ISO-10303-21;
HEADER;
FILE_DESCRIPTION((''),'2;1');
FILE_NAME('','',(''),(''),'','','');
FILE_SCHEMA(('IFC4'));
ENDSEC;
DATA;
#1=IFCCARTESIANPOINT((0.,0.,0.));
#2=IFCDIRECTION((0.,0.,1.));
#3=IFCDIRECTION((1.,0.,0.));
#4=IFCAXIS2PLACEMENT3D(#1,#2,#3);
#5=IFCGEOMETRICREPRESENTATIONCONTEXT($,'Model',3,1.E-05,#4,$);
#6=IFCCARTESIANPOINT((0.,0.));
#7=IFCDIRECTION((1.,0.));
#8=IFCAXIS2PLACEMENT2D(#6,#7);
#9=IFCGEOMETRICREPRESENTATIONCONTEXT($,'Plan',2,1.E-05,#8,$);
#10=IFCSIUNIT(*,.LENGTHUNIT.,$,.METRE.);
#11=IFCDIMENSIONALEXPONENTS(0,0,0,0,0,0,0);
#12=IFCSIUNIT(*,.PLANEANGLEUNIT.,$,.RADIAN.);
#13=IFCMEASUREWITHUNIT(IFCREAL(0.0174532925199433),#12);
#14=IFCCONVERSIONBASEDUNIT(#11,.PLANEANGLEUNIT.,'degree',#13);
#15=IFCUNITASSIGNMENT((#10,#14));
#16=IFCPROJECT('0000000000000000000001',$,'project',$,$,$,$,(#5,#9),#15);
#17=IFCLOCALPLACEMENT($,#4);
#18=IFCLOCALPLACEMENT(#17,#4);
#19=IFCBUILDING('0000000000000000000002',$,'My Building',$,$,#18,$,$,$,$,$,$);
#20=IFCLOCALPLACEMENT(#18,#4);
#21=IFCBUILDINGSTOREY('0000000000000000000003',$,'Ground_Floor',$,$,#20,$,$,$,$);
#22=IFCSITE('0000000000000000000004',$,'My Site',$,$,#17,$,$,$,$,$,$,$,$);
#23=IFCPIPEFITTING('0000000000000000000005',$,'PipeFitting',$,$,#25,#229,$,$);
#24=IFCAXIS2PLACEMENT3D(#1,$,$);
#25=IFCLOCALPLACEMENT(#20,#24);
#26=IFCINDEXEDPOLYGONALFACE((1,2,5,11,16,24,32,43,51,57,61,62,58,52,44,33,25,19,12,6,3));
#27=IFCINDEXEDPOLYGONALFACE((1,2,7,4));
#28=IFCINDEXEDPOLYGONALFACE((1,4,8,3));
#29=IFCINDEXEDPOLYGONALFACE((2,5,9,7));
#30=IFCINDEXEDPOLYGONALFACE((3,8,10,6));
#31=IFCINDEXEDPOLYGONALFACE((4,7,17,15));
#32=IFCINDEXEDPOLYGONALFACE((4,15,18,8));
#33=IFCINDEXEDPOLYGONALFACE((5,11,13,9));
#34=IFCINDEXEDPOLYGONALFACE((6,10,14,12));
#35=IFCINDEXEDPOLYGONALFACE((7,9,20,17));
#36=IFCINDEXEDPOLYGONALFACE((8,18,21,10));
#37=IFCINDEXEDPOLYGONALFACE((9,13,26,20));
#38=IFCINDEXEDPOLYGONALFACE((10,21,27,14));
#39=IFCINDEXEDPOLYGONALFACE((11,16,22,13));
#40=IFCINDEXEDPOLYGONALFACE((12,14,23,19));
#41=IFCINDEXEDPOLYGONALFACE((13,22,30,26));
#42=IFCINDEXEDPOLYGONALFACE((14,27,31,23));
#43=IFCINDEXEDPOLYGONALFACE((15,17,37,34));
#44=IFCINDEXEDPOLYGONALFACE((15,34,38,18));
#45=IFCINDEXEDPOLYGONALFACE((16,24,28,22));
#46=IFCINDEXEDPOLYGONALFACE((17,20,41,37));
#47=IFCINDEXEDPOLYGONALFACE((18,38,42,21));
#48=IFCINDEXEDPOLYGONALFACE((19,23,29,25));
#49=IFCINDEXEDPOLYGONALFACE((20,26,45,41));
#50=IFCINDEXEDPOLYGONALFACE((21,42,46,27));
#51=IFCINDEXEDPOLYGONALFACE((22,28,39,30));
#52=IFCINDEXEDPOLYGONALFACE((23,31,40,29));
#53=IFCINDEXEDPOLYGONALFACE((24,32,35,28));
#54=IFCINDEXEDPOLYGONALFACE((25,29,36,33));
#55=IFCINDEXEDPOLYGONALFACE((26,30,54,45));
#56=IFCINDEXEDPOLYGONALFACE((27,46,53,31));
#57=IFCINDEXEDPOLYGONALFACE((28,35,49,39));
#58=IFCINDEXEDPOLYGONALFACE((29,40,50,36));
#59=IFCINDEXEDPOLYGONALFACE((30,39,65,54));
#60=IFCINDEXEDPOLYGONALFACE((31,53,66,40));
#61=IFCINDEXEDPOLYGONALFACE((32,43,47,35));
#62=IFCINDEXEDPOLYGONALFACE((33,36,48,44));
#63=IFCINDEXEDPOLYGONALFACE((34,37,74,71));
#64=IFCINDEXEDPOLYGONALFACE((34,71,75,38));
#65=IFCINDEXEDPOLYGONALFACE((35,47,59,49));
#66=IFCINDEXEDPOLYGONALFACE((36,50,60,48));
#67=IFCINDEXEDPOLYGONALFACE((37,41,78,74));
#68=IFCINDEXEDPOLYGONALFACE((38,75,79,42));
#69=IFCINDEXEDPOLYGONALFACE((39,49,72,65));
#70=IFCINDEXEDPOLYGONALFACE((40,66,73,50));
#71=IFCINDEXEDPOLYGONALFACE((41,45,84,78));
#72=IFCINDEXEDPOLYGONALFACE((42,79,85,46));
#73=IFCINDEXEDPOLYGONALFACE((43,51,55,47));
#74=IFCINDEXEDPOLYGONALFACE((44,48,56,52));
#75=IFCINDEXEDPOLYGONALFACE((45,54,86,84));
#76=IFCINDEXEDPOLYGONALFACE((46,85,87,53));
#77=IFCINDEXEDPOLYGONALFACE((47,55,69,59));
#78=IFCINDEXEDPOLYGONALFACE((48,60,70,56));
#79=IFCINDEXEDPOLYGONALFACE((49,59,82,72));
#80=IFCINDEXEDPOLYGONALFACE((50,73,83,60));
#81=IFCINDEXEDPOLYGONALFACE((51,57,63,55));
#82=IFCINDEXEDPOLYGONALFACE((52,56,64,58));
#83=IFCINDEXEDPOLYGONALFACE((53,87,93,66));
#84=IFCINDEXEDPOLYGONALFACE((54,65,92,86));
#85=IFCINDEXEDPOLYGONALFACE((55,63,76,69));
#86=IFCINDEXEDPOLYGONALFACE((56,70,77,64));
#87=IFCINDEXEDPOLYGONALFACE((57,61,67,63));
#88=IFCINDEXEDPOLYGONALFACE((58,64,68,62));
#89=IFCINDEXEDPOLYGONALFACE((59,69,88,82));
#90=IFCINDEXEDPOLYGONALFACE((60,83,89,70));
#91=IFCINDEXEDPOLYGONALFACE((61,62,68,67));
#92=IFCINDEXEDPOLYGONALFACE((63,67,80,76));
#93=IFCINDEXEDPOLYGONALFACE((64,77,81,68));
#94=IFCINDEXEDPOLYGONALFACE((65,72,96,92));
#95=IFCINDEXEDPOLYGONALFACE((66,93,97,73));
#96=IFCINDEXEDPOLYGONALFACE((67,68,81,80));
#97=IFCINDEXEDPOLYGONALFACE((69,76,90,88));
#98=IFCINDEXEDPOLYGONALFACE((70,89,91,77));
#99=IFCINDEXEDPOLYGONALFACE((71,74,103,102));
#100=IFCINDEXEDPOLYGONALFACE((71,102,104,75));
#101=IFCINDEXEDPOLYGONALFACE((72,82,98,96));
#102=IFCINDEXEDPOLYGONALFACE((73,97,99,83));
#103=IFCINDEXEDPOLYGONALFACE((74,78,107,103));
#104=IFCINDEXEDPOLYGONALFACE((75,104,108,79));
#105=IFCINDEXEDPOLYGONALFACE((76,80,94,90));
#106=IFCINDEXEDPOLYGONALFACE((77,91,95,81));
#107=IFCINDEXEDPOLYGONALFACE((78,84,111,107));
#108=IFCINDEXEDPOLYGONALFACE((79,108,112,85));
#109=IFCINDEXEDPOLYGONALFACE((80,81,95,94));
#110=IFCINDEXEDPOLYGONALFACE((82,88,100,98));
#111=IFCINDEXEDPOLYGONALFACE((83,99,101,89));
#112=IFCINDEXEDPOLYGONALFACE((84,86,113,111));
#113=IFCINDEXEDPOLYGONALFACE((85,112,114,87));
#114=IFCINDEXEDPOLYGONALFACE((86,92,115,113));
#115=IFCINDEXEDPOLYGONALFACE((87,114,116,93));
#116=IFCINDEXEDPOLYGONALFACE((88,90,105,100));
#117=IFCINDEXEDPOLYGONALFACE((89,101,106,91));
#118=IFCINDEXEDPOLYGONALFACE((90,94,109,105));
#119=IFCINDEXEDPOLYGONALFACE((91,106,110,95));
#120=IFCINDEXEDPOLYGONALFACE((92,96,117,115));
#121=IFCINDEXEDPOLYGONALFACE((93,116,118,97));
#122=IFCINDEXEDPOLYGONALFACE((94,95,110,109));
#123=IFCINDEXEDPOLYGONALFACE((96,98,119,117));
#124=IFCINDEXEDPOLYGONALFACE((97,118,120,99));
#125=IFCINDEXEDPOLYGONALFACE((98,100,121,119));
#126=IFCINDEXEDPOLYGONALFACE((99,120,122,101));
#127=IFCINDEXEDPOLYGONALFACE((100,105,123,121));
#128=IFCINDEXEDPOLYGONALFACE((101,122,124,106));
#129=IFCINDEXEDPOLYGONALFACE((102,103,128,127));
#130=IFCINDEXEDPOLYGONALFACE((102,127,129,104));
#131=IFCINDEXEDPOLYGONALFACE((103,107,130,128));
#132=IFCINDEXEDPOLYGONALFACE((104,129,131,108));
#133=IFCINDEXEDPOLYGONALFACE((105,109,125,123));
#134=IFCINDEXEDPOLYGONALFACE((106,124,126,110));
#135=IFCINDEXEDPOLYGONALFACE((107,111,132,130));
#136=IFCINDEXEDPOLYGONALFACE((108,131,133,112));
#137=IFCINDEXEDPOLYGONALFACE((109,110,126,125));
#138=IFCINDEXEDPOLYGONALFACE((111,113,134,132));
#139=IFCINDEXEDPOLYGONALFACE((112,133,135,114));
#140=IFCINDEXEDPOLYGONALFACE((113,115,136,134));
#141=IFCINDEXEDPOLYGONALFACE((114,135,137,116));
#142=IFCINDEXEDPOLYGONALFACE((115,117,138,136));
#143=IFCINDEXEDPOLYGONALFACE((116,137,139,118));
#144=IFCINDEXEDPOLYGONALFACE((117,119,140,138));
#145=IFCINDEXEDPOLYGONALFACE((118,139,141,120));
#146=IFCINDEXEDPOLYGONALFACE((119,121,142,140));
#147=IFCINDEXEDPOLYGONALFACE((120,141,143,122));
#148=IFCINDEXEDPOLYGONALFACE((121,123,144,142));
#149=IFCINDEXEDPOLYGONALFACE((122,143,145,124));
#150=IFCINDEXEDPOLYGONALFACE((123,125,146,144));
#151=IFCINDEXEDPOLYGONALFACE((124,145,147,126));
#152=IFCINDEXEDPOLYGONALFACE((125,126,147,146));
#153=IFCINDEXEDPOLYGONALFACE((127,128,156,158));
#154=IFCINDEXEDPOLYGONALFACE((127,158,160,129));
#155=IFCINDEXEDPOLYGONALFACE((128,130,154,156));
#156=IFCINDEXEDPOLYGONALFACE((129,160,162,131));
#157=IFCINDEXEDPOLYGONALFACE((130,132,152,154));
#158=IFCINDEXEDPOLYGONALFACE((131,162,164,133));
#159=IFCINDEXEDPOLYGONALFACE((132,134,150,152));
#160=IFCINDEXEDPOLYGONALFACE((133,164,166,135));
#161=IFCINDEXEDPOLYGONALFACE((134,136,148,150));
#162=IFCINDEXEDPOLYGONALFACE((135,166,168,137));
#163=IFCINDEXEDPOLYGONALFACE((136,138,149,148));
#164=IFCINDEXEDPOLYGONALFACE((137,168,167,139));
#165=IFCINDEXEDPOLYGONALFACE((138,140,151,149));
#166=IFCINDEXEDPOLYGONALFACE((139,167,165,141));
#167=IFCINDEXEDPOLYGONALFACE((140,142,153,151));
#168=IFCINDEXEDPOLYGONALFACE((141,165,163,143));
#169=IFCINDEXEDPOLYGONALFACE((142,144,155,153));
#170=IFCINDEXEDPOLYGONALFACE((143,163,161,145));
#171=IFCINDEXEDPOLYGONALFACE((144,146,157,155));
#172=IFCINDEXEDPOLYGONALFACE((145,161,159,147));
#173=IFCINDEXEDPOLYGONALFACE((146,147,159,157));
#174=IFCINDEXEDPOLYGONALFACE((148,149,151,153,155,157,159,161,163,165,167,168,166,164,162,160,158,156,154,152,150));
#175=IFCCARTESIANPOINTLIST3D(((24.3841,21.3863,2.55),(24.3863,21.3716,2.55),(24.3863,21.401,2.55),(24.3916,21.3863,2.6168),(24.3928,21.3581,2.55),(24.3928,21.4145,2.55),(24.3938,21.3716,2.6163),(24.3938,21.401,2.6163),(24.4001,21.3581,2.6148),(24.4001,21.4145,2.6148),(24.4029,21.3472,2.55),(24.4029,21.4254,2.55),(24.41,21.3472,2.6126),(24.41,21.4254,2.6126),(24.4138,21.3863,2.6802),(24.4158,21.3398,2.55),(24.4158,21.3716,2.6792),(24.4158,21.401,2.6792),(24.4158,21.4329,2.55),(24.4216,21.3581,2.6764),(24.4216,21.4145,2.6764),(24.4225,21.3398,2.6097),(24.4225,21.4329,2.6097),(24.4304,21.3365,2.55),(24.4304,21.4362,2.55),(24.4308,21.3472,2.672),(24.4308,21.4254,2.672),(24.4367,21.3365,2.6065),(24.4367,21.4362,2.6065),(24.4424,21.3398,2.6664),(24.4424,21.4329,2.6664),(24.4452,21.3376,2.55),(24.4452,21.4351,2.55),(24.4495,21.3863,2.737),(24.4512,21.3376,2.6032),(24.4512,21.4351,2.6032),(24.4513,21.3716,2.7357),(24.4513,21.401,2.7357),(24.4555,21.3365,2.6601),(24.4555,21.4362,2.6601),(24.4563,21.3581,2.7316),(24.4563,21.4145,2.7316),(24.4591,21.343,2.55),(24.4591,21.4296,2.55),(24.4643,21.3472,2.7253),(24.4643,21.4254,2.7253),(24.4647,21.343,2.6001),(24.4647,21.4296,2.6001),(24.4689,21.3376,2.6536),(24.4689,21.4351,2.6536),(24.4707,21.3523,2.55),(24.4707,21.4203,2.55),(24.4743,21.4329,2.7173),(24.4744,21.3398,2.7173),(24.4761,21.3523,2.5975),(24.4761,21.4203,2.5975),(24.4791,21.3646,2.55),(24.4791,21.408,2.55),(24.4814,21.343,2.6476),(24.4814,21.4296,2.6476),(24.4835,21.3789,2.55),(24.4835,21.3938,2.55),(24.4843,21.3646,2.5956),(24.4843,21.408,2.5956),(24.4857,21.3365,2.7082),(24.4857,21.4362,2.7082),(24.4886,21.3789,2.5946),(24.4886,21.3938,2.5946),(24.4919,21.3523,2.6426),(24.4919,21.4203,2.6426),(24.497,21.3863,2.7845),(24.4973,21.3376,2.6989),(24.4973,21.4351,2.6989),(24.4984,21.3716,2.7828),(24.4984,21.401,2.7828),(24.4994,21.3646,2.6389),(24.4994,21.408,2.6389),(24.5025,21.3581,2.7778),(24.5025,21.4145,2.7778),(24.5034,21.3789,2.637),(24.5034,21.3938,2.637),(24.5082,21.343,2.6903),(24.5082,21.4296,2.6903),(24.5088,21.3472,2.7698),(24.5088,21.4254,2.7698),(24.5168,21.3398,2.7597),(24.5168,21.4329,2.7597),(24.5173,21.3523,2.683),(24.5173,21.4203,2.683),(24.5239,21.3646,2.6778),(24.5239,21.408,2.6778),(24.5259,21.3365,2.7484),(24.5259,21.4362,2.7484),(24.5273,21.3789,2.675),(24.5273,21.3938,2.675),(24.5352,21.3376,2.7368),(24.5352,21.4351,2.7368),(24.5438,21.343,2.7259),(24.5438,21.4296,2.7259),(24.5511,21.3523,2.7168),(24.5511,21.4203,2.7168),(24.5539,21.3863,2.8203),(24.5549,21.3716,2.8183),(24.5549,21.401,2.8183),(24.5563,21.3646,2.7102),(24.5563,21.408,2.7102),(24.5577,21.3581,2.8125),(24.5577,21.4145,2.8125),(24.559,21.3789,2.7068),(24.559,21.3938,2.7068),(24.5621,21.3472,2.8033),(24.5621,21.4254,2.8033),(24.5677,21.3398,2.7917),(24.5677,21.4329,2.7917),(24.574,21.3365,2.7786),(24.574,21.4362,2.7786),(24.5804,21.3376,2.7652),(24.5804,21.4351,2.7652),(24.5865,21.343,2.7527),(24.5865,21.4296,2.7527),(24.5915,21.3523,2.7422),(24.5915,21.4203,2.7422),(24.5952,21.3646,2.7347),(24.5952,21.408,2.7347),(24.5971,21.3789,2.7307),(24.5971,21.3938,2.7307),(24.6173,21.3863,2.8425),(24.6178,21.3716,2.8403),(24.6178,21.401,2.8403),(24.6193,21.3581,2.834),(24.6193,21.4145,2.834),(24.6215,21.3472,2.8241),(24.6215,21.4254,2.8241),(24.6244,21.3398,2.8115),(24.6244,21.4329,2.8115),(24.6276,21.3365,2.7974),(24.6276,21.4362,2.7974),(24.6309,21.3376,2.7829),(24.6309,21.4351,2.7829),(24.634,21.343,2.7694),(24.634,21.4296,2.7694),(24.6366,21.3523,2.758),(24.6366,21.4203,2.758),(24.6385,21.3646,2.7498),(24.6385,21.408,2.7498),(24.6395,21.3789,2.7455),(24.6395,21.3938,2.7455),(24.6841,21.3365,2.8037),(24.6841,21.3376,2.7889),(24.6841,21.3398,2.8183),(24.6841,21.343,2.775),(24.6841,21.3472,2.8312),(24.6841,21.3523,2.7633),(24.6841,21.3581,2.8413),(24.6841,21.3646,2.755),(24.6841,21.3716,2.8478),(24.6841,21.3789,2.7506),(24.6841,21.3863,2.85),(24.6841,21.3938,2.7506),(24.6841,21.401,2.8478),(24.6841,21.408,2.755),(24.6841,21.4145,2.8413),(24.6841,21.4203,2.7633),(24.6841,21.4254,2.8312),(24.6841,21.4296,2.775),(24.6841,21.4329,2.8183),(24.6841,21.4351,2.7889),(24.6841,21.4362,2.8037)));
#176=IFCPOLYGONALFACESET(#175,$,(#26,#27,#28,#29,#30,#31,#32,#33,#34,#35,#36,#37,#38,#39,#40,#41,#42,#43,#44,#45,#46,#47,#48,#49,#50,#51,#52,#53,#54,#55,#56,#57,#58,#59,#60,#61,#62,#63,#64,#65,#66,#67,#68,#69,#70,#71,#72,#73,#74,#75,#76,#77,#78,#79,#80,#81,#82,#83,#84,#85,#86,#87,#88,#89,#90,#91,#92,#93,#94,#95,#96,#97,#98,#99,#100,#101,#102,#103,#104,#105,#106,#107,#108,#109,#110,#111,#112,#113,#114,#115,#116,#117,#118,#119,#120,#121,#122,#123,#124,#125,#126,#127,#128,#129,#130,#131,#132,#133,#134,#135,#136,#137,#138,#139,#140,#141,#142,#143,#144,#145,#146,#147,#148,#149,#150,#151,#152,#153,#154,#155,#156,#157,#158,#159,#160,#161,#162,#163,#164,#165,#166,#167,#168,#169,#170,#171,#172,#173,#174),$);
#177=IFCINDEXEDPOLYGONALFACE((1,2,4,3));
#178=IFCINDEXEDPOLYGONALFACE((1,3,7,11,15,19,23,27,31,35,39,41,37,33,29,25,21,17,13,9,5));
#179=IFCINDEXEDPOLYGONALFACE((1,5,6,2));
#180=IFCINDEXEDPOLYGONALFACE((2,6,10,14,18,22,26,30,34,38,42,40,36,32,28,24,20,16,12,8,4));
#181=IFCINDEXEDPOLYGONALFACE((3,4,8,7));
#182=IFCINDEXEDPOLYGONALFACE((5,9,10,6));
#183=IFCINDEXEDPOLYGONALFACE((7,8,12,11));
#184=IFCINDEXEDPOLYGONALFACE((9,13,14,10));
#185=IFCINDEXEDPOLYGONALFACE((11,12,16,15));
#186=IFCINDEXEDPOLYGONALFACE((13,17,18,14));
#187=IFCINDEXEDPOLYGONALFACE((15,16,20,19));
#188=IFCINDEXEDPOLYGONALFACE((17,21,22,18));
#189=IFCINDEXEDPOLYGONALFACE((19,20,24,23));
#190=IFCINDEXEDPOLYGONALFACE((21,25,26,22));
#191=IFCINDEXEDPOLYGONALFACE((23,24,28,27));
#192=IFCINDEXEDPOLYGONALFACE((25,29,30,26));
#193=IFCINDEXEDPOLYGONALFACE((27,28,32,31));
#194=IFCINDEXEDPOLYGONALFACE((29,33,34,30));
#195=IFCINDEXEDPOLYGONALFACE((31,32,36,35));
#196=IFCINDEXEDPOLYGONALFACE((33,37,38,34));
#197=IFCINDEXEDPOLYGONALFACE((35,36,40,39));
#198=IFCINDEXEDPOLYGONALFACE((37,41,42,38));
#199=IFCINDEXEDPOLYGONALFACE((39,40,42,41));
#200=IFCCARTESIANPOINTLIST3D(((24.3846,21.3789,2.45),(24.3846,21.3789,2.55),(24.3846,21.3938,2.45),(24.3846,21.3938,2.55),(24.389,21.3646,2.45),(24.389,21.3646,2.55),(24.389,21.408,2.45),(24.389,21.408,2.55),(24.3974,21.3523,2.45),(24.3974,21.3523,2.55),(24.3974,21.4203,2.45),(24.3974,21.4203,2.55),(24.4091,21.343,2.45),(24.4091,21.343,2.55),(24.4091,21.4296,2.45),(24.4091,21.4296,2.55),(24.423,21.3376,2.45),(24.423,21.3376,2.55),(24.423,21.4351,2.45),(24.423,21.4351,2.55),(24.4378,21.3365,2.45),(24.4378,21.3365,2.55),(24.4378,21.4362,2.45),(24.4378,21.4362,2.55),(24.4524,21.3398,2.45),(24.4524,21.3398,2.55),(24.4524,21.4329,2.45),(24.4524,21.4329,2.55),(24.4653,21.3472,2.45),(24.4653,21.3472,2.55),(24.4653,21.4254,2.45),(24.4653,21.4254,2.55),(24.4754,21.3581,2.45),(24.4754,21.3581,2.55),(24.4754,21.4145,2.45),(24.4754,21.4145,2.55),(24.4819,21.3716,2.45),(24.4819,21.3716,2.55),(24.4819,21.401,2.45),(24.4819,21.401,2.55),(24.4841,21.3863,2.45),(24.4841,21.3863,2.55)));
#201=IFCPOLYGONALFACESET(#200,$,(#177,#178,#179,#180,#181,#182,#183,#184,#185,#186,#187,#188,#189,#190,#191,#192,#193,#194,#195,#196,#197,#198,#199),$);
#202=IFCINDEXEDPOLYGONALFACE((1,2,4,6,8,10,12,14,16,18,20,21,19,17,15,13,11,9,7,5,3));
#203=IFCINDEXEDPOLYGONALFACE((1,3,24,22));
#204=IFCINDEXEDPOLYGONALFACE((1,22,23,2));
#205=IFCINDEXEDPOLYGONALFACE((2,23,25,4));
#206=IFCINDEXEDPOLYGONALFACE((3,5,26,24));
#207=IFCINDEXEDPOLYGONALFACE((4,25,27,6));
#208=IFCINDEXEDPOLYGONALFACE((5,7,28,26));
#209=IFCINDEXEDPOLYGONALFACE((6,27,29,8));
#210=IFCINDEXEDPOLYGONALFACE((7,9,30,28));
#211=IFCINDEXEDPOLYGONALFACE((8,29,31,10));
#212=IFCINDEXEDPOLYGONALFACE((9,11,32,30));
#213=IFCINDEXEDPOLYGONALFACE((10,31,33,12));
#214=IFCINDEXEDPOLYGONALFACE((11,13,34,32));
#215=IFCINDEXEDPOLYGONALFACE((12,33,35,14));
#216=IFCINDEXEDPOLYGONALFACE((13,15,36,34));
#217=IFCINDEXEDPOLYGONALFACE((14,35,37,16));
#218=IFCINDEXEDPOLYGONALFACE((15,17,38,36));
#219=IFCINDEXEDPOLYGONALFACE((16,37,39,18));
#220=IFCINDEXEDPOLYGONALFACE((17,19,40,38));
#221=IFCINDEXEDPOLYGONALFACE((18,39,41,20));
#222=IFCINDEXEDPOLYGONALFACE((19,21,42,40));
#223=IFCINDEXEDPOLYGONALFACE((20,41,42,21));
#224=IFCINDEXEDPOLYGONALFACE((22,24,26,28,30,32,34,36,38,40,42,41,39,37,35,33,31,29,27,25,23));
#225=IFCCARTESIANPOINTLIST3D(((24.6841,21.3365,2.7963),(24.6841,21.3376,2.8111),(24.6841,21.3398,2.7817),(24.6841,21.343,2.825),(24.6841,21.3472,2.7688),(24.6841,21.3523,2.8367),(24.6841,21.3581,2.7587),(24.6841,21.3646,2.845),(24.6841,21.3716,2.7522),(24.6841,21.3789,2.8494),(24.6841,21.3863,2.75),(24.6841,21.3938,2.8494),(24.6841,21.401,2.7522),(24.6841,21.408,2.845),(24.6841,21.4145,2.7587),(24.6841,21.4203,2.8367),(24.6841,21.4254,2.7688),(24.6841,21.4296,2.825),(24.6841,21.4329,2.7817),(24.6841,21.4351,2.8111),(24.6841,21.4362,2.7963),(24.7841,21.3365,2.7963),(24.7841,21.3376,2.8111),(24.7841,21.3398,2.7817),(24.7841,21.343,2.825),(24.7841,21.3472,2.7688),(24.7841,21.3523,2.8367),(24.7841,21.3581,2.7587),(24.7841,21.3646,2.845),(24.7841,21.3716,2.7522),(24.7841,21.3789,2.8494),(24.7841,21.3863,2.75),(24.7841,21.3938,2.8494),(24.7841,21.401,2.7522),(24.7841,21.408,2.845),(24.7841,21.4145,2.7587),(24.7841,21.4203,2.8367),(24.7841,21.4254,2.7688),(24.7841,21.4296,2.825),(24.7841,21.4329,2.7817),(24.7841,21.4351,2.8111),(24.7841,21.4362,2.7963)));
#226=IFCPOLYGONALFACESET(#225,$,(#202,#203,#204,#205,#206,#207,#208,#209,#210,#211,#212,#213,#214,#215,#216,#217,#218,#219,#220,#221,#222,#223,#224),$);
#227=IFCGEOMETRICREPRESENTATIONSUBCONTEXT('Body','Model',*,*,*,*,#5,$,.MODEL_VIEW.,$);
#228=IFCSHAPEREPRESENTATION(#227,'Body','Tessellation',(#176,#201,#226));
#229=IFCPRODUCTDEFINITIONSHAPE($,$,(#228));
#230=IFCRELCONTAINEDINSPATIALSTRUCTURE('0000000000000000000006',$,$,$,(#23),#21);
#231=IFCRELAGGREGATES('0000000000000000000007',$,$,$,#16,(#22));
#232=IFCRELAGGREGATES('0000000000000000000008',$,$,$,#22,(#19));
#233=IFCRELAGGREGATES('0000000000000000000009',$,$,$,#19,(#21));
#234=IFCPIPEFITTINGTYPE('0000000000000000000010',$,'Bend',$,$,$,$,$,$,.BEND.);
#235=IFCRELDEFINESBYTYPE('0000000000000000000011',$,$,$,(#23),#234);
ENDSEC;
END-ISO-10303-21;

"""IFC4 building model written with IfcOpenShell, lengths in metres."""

from ifc_helpers import new_model, entity, si_unit, converted_unit, frame, origin_with_axes, origin_2d_with_axis, place, context, subcontext, project, spatial, circle, extrude, source, transform, mapped, type_object, type_shapes, element, save


model = new_model("IFC4")

# Units and contexts
model_context = context("Model", 3, precision=1e-05, world=origin_with_axes())
plan_context = context("Plan", 2, precision=1e-05, world=origin_2d_with_axis())
body_context = subcontext(model_context, "Body", "Model", "MODEL_VIEW")
ifc_project = project(units=[si_unit("LENGTHUNIT", "METRE"), converted_unit("PLANEANGLEUNIT", "degree", entity("IfcReal", 0.0174532925199433), si_unit("PLANEANGLEUNIT", "RADIAN"), dimensions=[0, 0, 0, 0, 0, 0, 0])], contexts=[model_context, plan_context])

# Site, building, storey
site_placement = place(None, origin_with_axes())
site = spatial("IfcSite", under=ifc_project, at=site_placement, Name="My Site")
building_placement = place(site_placement, origin_with_axes())
building = spatial("IfcBuilding", under=site, at=building_placement, Name="My Building")
storey_placement = place(building_placement, origin_with_axes())
storey = spatial("IfcBuildingStorey", under=building, at=storey_placement, Name="Ground_Floor")

# Pipe fitting
pipe_fitting_type = type_object("IfcPipeFittingType", Name="Bend", PredefinedType="BEND")
shared_shape = source(origin_with_axes(), body_context, "Body", "SolidModel", [
    entity("IfcSweptDiskSolid", entity("IfcIndexedPolyCurve", entity("IfcCartesianPointList3D", [[0.0, 0.0, -0.1], [0.0732, 0.0, -0.2768], [0.25, 0.0, -0.35]]), [entity("IfcArcIndex", [1, 2, 3])]), 0.05),
    extrude(circle(Radius=0.05), origin_with_axes(), (0.0, 0.0, -1.0), 0.1),
    extrude(circle(Radius=0.05), frame((0.25, 0.0, -0.35), z_axis=(1.0, 0.0, 0.0), x_axis=(0.0, 0.0, 1.0)), (0.0, 0.0, 1.0), 0.1),
])
type_shapes(pipe_fitting_type, [shared_shape])
for number, where, z_axis, x_axis, name in (
    (1, (24.4341, 21.3863, 2.45), (0.0, 0.0, -1.0), (1.0, 0.0, 0.0), "PipeFitting"),
):
    element("IfcPipeFitting", number, at=place(storey_placement, frame(where, z_axis=z_axis, x_axis=x_axis)), inside=storey, type_object=pipe_fitting_type, Name=name, context=body_context, shape_type="MappedRepresentation", body=[
        mapped(shared_shape, transform((0.0, 0.0, 0.0), x_axis=(1.0, 0.0, 0.0), y_axis=(0.0, 1.0, 0.0), z_axis=(0.0, 0.0, 1.0), scale=1.0)),
    ])

save(model, "model.ifc")
